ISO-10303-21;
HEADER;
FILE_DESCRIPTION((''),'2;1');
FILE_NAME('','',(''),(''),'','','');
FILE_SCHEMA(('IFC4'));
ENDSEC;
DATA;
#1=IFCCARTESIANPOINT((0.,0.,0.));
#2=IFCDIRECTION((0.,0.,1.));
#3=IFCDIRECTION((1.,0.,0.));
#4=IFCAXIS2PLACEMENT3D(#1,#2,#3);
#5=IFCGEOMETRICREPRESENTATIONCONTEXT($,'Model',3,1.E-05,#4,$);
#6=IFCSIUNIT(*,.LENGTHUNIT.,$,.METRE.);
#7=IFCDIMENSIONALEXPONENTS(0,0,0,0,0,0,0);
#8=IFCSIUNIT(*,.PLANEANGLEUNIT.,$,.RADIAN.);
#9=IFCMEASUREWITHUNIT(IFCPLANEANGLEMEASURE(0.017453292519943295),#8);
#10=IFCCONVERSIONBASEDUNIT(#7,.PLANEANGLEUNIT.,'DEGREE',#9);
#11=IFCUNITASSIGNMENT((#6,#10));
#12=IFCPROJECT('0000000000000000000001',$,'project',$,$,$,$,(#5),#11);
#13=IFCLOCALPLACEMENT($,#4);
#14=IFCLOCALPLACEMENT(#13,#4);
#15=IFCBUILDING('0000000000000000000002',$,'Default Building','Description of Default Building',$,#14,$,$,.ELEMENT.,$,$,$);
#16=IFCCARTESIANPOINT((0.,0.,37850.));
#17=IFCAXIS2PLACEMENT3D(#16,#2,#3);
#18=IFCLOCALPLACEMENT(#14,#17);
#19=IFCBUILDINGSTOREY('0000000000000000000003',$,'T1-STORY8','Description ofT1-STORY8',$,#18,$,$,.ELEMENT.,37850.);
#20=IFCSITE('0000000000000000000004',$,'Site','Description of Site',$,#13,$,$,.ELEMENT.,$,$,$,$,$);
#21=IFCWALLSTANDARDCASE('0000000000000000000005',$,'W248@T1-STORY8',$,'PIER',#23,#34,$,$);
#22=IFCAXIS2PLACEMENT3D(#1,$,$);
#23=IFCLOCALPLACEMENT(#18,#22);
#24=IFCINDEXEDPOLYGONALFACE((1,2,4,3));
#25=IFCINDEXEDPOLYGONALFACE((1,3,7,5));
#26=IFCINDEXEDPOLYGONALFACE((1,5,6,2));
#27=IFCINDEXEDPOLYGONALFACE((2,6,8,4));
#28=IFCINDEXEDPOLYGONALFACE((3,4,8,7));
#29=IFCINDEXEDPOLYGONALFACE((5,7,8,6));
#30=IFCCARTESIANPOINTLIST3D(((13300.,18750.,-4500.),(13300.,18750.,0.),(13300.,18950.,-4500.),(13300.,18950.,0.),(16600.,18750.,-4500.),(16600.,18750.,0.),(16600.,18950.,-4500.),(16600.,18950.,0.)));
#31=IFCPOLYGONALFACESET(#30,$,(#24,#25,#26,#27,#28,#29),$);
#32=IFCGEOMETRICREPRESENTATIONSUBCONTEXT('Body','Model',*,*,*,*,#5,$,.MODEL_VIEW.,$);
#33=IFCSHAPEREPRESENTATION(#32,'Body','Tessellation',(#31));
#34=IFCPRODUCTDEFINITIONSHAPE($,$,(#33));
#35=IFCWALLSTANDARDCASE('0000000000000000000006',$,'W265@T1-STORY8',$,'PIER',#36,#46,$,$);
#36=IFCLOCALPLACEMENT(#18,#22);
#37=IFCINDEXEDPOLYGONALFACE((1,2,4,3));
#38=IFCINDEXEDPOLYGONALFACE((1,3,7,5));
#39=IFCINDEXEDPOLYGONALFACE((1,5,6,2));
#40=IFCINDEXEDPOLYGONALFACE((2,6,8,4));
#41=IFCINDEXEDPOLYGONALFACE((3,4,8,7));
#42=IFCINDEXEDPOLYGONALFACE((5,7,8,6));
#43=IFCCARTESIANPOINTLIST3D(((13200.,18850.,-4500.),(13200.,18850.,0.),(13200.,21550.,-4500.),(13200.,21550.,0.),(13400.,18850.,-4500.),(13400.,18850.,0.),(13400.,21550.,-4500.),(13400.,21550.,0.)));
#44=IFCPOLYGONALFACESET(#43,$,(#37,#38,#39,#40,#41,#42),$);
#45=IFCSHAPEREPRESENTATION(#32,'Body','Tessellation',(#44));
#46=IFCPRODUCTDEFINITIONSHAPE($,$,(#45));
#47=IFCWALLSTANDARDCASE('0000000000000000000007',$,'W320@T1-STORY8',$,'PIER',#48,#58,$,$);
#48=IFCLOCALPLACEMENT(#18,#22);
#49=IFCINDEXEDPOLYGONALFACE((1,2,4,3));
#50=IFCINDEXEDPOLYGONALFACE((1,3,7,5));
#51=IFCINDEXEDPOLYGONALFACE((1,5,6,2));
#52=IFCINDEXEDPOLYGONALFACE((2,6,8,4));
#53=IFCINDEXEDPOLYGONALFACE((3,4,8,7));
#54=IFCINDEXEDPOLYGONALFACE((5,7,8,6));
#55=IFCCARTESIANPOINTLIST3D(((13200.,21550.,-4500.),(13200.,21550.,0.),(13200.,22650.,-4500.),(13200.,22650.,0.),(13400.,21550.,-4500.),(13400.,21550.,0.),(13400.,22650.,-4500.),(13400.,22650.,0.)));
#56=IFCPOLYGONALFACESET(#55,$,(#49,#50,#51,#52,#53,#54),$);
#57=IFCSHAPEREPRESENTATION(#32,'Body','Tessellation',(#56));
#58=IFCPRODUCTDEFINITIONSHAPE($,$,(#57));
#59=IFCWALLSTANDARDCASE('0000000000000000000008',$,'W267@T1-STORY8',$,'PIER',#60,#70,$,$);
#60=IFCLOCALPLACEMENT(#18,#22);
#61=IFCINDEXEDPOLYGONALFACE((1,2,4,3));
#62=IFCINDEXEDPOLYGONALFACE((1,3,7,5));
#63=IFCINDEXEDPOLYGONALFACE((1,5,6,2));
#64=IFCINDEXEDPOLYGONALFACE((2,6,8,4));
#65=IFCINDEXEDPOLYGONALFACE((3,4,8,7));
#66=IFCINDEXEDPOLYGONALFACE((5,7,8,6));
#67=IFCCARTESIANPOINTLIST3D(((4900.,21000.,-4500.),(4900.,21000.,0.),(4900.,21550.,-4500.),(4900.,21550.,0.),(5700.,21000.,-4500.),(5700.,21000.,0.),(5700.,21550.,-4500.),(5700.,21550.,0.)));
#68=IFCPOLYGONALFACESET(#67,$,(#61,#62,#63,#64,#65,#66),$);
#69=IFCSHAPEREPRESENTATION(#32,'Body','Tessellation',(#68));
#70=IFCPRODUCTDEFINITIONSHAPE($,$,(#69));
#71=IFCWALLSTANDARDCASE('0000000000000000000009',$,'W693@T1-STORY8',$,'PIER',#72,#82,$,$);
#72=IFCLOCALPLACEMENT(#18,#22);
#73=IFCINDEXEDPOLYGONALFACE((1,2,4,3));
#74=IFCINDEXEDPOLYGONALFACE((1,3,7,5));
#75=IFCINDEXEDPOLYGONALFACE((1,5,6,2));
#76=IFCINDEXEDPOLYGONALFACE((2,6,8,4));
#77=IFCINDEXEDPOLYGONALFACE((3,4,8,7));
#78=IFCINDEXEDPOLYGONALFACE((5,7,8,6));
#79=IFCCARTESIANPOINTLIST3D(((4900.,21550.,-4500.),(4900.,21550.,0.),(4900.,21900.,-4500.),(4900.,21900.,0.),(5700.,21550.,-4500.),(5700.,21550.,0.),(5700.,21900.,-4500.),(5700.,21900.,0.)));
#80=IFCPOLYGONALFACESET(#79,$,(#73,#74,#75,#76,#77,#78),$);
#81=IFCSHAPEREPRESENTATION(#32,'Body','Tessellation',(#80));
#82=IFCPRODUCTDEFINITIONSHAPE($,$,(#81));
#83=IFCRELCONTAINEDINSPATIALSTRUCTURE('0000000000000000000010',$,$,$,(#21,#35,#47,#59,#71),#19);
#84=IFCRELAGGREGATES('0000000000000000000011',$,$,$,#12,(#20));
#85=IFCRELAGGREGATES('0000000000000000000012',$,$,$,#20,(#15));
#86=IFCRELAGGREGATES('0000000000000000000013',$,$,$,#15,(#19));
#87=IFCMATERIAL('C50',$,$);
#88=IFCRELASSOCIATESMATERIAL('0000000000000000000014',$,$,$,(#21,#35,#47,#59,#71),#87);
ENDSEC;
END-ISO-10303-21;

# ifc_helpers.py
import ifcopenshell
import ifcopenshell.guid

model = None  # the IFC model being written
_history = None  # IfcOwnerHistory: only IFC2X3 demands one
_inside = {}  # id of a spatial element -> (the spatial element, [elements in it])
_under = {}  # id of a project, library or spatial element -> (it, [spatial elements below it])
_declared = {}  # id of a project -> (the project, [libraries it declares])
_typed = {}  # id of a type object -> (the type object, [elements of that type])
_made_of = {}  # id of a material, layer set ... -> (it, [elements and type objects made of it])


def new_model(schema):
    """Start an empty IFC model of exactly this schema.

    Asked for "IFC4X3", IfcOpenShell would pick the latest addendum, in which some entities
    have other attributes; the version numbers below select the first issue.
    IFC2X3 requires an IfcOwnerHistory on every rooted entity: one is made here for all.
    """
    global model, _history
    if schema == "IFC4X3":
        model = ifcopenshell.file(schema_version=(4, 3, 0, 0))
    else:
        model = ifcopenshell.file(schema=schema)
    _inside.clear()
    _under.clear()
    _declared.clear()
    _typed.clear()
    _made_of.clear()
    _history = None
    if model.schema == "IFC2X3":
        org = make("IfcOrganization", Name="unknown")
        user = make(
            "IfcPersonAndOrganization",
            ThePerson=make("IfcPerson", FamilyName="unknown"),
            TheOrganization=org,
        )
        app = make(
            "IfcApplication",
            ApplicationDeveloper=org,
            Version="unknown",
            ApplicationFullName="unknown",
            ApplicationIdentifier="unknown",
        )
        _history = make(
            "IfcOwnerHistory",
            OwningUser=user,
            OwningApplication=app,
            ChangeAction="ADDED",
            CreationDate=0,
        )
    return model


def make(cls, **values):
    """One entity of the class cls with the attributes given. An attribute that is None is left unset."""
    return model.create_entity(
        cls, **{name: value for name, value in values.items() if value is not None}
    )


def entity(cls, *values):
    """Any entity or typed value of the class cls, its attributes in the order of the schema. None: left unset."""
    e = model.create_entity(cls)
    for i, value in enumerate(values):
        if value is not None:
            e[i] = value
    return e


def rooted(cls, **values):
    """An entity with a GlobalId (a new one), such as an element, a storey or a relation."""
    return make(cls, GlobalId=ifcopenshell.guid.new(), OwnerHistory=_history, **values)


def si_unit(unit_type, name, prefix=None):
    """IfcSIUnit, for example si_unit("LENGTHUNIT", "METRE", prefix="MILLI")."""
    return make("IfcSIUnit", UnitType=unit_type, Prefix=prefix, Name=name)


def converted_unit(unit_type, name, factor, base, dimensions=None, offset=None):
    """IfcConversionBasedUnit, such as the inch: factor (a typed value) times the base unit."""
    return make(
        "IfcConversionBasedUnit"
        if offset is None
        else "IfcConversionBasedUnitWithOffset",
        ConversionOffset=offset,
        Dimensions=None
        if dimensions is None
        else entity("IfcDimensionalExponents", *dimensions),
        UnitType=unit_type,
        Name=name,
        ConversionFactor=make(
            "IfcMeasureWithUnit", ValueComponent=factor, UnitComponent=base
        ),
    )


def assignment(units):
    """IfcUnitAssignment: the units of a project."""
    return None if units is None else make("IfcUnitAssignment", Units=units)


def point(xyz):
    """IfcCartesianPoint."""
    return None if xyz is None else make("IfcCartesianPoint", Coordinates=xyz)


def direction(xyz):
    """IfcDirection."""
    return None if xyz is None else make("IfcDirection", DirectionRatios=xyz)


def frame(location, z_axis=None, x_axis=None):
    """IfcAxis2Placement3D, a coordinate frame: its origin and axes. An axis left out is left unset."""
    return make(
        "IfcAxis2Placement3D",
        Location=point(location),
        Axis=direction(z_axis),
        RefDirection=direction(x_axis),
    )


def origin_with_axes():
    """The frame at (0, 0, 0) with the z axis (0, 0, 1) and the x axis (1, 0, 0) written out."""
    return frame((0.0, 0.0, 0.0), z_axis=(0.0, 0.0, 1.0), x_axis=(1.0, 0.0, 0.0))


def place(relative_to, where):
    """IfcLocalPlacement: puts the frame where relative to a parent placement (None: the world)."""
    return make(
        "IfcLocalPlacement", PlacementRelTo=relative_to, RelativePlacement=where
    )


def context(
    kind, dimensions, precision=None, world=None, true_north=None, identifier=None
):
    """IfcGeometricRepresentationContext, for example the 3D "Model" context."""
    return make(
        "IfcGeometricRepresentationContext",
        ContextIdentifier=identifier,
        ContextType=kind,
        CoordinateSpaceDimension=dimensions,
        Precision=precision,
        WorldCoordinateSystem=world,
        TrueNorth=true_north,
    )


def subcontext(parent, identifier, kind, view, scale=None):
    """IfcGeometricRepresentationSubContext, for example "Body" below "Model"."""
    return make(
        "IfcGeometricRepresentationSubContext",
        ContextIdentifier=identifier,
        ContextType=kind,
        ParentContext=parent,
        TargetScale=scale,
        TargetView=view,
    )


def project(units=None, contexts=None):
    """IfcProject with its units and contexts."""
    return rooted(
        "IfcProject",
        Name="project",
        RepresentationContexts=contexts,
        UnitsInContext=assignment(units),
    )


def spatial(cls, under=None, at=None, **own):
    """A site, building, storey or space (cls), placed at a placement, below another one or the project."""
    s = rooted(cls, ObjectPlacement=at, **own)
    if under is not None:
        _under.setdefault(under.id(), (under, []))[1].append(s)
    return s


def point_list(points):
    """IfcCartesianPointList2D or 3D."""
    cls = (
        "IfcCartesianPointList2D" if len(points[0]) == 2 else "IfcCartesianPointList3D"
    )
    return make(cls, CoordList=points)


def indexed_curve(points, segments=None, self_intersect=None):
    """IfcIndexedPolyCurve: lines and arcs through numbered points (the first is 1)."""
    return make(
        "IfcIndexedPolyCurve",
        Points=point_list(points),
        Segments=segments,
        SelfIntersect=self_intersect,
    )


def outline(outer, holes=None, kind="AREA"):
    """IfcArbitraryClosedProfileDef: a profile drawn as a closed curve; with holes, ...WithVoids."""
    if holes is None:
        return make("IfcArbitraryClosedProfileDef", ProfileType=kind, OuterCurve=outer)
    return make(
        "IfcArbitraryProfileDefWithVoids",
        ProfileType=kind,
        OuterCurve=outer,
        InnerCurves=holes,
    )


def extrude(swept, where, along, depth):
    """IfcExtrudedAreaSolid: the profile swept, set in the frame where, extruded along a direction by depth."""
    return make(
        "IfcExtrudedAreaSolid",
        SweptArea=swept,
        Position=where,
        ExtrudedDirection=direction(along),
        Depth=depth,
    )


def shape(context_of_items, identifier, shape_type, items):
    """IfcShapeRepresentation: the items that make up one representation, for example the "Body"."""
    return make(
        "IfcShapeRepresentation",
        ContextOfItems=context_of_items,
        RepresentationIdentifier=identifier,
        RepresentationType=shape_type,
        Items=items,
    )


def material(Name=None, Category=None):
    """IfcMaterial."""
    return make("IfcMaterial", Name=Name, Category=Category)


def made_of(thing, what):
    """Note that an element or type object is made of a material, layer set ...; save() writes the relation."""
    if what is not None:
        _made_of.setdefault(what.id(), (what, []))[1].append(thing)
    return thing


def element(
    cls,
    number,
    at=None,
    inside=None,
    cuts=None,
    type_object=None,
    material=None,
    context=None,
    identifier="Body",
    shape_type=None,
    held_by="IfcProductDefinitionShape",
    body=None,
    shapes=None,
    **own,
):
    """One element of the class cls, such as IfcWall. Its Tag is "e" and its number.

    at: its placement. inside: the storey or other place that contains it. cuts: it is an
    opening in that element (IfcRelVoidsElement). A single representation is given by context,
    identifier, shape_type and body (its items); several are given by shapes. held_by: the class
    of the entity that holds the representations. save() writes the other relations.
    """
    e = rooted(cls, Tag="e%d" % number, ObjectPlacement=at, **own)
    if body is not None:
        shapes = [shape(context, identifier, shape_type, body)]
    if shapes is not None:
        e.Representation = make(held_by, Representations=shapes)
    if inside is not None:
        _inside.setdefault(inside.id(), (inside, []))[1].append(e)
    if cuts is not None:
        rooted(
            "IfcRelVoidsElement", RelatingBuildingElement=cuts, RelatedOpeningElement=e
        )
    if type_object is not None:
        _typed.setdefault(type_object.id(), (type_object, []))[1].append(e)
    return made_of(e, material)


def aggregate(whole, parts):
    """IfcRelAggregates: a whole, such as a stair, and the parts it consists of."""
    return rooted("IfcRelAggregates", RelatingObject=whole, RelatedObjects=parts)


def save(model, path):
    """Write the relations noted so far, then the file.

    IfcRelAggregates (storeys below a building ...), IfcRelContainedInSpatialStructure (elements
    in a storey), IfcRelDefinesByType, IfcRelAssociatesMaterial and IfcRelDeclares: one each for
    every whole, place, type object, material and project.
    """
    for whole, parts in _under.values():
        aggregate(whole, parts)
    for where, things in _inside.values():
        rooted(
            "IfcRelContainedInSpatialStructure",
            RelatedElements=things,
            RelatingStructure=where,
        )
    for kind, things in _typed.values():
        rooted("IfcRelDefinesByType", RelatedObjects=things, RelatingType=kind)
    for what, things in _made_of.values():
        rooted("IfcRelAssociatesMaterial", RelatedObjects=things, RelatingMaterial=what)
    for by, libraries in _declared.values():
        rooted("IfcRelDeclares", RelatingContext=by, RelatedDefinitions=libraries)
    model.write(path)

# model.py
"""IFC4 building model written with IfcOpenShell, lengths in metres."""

from ifc_helpers import new_model, entity, si_unit, converted_unit, frame, origin_with_axes, place, context, subcontext, project, spatial, indexed_curve, outline, extrude, material, element, save


model = new_model("IFC4")

# Units and contexts
model_context = context("Model", 3, precision=1e-05, world=origin_with_axes())
body_context = subcontext(model_context, "Body", "Model", "MODEL_VIEW")
ifc_project = project(units=[si_unit("LENGTHUNIT", "METRE"), converted_unit("PLANEANGLEUNIT", "DEGREE", entity("IfcPlaneAngleMeasure", 0.017453292519943295), si_unit("PLANEANGLEUNIT", "RADIAN"), dimensions=[0, 0, 0, 0, 0, 0, 0])], contexts=[model_context])

# Site, building, storey
site_placement = place(None, origin_with_axes())
site = spatial("IfcSite", under=ifc_project, at=site_placement, Name="Site", Description="Description of Site", CompositionType="ELEMENT")
building_placement = place(site_placement, origin_with_axes())
building = spatial("IfcBuilding", under=site, at=building_placement, Name="Default Building", Description="Description of Default Building", CompositionType="ELEMENT")
storey_placement = place(building_placement, frame((0.0, 0.0, 37850.0), z_axis=(0.0, 0.0, 1.0), x_axis=(1.0, 0.0, 0.0)))
storey = spatial("IfcBuildingStorey", under=building, at=storey_placement, Name="T1-STORY8", Description="Description ofT1-STORY8", CompositionType="ELEMENT", Elevation=37850.0)

# Shared definitions
ifc_material_1 = material(Name="C50")

# Walls
wall_1_placement = place(storey_placement, frame((13300.0, 18850.0, -4500.0), z_axis=(0.0, 0.0, 1.0), x_axis=(1.0, 0.0, 0.0)))
element("IfcWallStandardCase", 1, at=wall_1_placement, inside=storey, material=ifc_material_1, Name="W248@T1-STORY8", ObjectType="PIER", context=body_context, shape_type="SweptSolid", body=[
    extrude(outline(indexed_curve([(0.0, -100.0), (0.0, 100.0), (3300.0, 100.0), (3300.0, -100.0), (0.0, -100.0)], self_intersect=False)), origin_with_axes(), (0.0, 0.0, 1.0), 4500.0),
])
wall_2_placement = place(storey_placement, frame((13300.0, 18850.0, -4500.0), z_axis=(0.0, 0.0, 1.0), x_axis=(0.0, 1.0, 0.0)))
element("IfcWallStandardCase", 2, at=wall_2_placement, inside=storey, material=ifc_material_1, Name="W265@T1-STORY8", ObjectType="PIER", context=body_context, shape_type="SweptSolid", body=[
    extrude(outline(indexed_curve([(0.0, -100.0), (0.0, 100.0), (2700.0, 100.0), (2700.0, -100.0), (0.0, -100.0)], self_intersect=False)), origin_with_axes(), (0.0, 0.0, 1.0), 4500.0),
])
wall_3_placement = place(storey_placement, frame((13300.0, 21550.0, -4500.0), z_axis=(0.0, 0.0, 1.0), x_axis=(0.0, 1.0, 0.0)))
element("IfcWallStandardCase", 3, at=wall_3_placement, inside=storey, material=ifc_material_1, Name="W320@T1-STORY8", ObjectType="PIER", context=body_context, shape_type="SweptSolid", body=[
    extrude(outline(indexed_curve([(0.0, -100.0), (0.0, 100.0), (1100.0, 100.0), (1100.0, -100.0), (0.0, -100.0)], self_intersect=False)), origin_with_axes(), (0.0, 0.0, 1.0), 4500.0),
])
wall_4_placement = place(storey_placement, frame((5300.0, 21000.0, -4500.0), z_axis=(0.0, 0.0, 1.0), x_axis=(0.0, 1.0, 0.0)))
element("IfcWallStandardCase", 4, at=wall_4_placement, inside=storey, material=ifc_material_1, Name="W267@T1-STORY8", ObjectType="PIER", context=body_context, shape_type="SweptSolid", body=[
    extrude(outline(indexed_curve([(0.0, -400.0), (0.0, 400.0), (550.0, 400.0), (550.0, -400.0), (0.0, -400.0)], self_intersect=False)), origin_with_axes(), (0.0, 0.0, 1.0), 4500.0),
])
wall_5_placement = place(storey_placement, frame((5300.0, 21550.0, -4500.0), z_axis=(0.0, 0.0, 1.0), x_axis=(0.0, 1.0, 0.0)))
element("IfcWallStandardCase", 5, at=wall_5_placement, inside=storey, material=ifc_material_1, Name="W693@T1-STORY8", ObjectType="PIER", context=body_context, shape_type="SweptSolid", body=[
    extrude(outline(indexed_curve([(0.0, -400.0), (0.0, 400.0), (350.0, 400.0), (350.0, -400.0), (0.0, -400.0)], self_intersect=False)), origin_with_axes(), (0.0, 0.0, 1.0), 4500.0),
])

save(model, "model.ifc")
